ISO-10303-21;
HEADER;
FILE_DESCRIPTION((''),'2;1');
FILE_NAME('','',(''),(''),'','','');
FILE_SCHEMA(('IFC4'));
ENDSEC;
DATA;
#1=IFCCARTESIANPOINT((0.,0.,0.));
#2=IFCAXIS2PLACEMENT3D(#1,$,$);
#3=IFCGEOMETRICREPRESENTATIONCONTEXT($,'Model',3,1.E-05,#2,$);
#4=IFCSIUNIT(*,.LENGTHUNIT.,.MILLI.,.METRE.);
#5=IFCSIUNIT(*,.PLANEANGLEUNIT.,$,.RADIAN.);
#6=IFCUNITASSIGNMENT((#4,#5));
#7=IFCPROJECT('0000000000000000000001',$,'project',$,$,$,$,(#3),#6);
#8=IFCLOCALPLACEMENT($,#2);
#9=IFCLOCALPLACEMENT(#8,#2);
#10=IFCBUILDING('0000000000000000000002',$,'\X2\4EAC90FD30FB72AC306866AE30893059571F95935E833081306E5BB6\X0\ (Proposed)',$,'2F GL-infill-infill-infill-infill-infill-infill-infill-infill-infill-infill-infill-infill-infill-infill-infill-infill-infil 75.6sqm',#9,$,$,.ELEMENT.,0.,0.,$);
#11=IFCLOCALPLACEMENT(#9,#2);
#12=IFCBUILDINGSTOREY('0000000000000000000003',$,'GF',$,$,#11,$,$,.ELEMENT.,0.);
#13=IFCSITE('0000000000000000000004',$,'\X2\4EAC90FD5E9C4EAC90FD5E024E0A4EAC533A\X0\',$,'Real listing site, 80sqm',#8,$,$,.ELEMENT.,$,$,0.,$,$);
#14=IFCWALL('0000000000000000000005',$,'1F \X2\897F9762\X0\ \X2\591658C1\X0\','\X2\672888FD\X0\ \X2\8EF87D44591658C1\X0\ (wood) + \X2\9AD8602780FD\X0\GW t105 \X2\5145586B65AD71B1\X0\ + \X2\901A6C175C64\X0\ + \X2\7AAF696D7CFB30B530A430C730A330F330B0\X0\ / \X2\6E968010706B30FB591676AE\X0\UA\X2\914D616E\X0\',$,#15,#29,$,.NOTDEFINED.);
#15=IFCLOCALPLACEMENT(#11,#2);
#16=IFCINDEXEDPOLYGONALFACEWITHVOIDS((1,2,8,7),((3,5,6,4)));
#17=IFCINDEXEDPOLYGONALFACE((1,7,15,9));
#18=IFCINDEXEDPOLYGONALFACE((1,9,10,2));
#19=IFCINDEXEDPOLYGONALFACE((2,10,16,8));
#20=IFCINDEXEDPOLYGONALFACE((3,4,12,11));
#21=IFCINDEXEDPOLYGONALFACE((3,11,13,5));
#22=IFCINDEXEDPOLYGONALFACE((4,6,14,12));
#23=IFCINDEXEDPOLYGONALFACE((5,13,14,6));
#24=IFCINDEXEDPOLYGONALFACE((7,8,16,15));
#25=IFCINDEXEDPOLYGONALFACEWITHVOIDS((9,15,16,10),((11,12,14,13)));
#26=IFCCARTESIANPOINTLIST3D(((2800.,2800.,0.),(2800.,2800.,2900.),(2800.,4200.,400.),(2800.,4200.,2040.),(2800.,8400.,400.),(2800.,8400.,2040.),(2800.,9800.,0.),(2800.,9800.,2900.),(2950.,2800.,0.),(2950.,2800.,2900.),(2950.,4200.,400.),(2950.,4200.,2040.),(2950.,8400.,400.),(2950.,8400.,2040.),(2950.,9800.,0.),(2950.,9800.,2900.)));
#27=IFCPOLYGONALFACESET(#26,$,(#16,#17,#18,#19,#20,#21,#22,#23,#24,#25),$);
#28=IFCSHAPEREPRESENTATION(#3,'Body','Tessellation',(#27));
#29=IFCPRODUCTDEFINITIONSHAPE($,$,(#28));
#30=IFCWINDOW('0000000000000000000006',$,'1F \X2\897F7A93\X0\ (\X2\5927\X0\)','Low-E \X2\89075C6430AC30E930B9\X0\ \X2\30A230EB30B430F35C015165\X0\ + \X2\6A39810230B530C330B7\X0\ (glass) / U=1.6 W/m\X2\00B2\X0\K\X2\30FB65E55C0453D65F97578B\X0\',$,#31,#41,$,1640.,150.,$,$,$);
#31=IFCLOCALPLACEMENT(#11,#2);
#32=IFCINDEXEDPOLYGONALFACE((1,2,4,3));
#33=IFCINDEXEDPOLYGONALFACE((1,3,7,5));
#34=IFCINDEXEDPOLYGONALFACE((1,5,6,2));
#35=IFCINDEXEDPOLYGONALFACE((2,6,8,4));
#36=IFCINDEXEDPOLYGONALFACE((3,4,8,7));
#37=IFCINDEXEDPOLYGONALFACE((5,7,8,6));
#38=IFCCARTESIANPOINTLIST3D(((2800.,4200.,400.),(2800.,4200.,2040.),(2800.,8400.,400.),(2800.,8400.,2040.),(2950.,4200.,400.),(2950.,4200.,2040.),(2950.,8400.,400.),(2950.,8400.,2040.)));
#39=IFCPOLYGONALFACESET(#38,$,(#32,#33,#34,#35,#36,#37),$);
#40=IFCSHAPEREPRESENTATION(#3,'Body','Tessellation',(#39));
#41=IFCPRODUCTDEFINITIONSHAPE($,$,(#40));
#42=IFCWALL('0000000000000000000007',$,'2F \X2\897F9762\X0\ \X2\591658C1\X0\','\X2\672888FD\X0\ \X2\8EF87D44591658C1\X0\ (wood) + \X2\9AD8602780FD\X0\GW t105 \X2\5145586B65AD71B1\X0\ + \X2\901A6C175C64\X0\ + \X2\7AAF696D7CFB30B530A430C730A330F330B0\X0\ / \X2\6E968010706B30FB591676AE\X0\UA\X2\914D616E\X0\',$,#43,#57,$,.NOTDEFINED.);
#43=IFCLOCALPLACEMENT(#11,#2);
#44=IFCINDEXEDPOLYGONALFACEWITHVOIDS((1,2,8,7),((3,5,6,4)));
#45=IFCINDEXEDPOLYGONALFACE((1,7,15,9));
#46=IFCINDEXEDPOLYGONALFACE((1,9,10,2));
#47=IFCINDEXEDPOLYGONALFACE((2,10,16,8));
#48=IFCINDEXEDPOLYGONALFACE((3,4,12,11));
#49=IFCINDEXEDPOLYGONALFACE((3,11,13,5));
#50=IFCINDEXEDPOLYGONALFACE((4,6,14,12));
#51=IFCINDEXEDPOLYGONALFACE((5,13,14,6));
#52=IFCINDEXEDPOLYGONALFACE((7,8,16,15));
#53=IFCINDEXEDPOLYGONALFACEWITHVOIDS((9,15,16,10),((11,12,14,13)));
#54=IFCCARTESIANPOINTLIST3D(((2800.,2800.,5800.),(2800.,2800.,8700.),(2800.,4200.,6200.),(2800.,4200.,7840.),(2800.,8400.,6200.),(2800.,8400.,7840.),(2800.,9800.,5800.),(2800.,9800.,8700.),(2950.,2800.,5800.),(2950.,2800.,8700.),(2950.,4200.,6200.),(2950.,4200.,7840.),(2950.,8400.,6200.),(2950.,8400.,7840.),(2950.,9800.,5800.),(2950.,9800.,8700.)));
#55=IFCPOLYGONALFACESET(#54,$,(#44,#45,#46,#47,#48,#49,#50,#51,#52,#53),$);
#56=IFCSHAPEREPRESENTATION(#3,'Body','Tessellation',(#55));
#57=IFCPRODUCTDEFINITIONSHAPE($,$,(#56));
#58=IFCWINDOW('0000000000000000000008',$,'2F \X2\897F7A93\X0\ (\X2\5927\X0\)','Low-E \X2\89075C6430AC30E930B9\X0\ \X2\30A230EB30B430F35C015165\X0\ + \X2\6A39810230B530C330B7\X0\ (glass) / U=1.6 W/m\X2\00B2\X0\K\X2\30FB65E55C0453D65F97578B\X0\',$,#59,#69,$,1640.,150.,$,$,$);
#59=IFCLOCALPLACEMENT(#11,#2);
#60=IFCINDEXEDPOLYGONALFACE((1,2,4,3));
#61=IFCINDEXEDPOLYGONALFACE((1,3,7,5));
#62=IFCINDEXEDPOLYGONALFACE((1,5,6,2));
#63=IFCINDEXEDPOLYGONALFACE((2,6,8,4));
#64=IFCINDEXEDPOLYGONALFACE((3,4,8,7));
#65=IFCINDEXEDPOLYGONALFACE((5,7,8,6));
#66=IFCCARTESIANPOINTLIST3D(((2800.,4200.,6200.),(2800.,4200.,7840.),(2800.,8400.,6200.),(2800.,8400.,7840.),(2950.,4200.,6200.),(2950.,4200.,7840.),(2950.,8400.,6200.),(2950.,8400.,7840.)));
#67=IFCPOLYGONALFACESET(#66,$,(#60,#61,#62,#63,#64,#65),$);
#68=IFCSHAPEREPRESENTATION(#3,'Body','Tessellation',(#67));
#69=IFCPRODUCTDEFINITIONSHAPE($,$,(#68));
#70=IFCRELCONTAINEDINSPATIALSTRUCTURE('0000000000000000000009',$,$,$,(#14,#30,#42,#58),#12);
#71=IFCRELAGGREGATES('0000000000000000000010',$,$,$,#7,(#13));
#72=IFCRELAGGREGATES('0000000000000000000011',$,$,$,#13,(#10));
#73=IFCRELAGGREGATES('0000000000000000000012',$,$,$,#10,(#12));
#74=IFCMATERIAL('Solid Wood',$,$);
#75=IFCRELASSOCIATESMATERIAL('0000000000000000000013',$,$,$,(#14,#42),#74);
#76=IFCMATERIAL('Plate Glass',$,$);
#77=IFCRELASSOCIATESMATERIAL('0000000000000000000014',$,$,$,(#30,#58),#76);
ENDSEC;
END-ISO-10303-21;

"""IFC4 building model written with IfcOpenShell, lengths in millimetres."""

from ifc_helpers import new_model, si_unit, frame, frame_2d, origin, place, context, project, spatial, rectangle, extrude, material, element, fill, save


model = new_model("IFC4")

# Units and contexts
model_context = context("Model", 3, precision=1e-05, world=origin())
ifc_project = project(units=[si_unit("LENGTHUNIT", "METRE", prefix="MILLI"), si_unit("PLANEANGLEUNIT", "RADIAN")], contexts=[model_context])

# Site, building, storey
site_placement = place(None, origin())
site = spatial("IfcSite", under=ifc_project, at=site_placement, Name="京都府京都市上京区", ObjectType="Real listing site, 80sqm", CompositionType="ELEMENT", RefElevation=0.0)
building_placement = place(site_placement, origin())
building = spatial("IfcBuilding", under=site, at=building_placement, Name="京都・犬と暮らす土間広めの家 (Proposed)", ObjectType="2F GL-infill-infill-infill-infill-infill-infill-infill-infill-infill-infill-infill-infill-infill-infill-infill-infill-infil 75.6sqm", CompositionType="ELEMENT", ElevationOfRefHeight=0.0, ElevationOfTerrain=0.0)
storey_placement = place(building_placement, origin())
storey = spatial("IfcBuildingStorey", under=building, at=storey_placement, Name="GF", CompositionType="ELEMENT", Elevation=0.0)

# Shared definitions
ifc_material_1 = material(Name="Solid Wood")

# Shared definitions
ifc_material_2 = material(Name="Plate Glass")

# Wall, opening, window
wall_1_placement = place(storey_placement, frame((1400.0, 1400.0, 0.0)))
wall_1 = element("IfcWall", 1, at=wall_1_placement, inside=storey, material=ifc_material_1, Name="1F 西面 外壁", Description="木製 軸組外壁 (wood) + 高性能GW t105 充填断熱 + 通気層 + 窯業系サイディング / 準耐火・外皮UA配慮", PredefinedType="NOTDEFINED", context=model_context, shape_type="SweptSolid", body=[
    extrude(rectangle(XDim=150.0, YDim=7000.0, at=frame_2d((75.0, 3500.0))), frame((1400.0, 1400.0, 0.0)), (0.0, 0.0, 1.0), 2900.0),
])
opening_1_placement = place(storey_placement, frame((1400.0, 2100.0, 200.0)))
opening_1 = element("IfcOpeningElement", 2, at=opening_1_placement, cuts=wall_1, PredefinedType="NOTDEFINED", context=model_context, shape_type="SweptSolid", body=[
    extrude(rectangle(XDim=150.0, YDim=4200.0, at=frame_2d((75.0, 2100.0))), frame((1400.0, 2100.0, 200.0)), (0.0, 0.0, 1.0), 1640.0),
])
window_1_placement = place(storey_placement, frame((1400.0, 2100.0, 200.0)))
window_1 = element("IfcWindow", 3, at=window_1_placement, inside=storey, material=ifc_material_2, Name="1F 西窓 (大)", Description="Low-E 複層ガラス アルゴン封入 + 樹脂サッシ (glass) / U=1.6 W/m²K・日射取得型", OverallHeight=1640.0, OverallWidth=150.0, context=model_context, shape_type="SweptSolid", body=[
    extrude(rectangle(XDim=150.0, YDim=4200.0, at=frame_2d((75.0, 2100.0))), frame((1400.0, 2100.0, 200.0)), (0.0, 0.0, 1.0), 1640.0),
])
fill(opening_1, window_1)

# Wall, opening, window
wall_2_placement = place(storey_placement, frame((1400.0, 1400.0, 2900.0)))
wall_2 = element("IfcWall", 4, at=wall_2_placement, inside=storey, material=ifc_material_1, Name="2F 西面 外壁", Description="木製 軸組外壁 (wood) + 高性能GW t105 充填断熱 + 通気層 + 窯業系サイディング / 準耐火・外皮UA配慮", PredefinedType="NOTDEFINED", context=model_context, shape_type="SweptSolid", body=[
    extrude(rectangle(XDim=150.0, YDim=7000.0, at=frame_2d((75.0, 3500.0))), frame((1400.0, 1400.0, 2900.0)), (0.0, 0.0, 1.0), 2900.0),
])
opening_2_placement = place(storey_placement, frame((1400.0, 2100.0, 3100.0)))
opening_2 = element("IfcOpeningElement", 5, at=opening_2_placement, cuts=wall_2, PredefinedType="NOTDEFINED", context=model_context, shape_type="SweptSolid", body=[
    extrude(rectangle(XDim=150.0, YDim=4200.0, at=frame_2d((75.0, 2100.0))), frame((1400.0, 2100.0, 3100.0)), (0.0, 0.0, 1.0), 1640.0),
])
window_2_placement = place(storey_placement, frame((1400.0, 2100.0, 3100.0)))
window_2 = element("IfcWindow", 6, at=window_2_placement, inside=storey, material=ifc_material_2, Name="2F 西窓 (大)", Description="Low-E 複層ガラス アルゴン封入 + 樹脂サッシ (glass) / U=1.6 W/m²K・日射取得型", OverallHeight=1640.0, OverallWidth=150.0, context=model_context, shape_type="SweptSolid", body=[
    extrude(rectangle(XDim=150.0, YDim=4200.0, at=frame_2d((75.0, 2100.0))), frame((1400.0, 2100.0, 3100.0)), (0.0, 0.0, 1.0), 1640.0),
])
fill(opening_2, window_2)

save(model, "model.ifc")
